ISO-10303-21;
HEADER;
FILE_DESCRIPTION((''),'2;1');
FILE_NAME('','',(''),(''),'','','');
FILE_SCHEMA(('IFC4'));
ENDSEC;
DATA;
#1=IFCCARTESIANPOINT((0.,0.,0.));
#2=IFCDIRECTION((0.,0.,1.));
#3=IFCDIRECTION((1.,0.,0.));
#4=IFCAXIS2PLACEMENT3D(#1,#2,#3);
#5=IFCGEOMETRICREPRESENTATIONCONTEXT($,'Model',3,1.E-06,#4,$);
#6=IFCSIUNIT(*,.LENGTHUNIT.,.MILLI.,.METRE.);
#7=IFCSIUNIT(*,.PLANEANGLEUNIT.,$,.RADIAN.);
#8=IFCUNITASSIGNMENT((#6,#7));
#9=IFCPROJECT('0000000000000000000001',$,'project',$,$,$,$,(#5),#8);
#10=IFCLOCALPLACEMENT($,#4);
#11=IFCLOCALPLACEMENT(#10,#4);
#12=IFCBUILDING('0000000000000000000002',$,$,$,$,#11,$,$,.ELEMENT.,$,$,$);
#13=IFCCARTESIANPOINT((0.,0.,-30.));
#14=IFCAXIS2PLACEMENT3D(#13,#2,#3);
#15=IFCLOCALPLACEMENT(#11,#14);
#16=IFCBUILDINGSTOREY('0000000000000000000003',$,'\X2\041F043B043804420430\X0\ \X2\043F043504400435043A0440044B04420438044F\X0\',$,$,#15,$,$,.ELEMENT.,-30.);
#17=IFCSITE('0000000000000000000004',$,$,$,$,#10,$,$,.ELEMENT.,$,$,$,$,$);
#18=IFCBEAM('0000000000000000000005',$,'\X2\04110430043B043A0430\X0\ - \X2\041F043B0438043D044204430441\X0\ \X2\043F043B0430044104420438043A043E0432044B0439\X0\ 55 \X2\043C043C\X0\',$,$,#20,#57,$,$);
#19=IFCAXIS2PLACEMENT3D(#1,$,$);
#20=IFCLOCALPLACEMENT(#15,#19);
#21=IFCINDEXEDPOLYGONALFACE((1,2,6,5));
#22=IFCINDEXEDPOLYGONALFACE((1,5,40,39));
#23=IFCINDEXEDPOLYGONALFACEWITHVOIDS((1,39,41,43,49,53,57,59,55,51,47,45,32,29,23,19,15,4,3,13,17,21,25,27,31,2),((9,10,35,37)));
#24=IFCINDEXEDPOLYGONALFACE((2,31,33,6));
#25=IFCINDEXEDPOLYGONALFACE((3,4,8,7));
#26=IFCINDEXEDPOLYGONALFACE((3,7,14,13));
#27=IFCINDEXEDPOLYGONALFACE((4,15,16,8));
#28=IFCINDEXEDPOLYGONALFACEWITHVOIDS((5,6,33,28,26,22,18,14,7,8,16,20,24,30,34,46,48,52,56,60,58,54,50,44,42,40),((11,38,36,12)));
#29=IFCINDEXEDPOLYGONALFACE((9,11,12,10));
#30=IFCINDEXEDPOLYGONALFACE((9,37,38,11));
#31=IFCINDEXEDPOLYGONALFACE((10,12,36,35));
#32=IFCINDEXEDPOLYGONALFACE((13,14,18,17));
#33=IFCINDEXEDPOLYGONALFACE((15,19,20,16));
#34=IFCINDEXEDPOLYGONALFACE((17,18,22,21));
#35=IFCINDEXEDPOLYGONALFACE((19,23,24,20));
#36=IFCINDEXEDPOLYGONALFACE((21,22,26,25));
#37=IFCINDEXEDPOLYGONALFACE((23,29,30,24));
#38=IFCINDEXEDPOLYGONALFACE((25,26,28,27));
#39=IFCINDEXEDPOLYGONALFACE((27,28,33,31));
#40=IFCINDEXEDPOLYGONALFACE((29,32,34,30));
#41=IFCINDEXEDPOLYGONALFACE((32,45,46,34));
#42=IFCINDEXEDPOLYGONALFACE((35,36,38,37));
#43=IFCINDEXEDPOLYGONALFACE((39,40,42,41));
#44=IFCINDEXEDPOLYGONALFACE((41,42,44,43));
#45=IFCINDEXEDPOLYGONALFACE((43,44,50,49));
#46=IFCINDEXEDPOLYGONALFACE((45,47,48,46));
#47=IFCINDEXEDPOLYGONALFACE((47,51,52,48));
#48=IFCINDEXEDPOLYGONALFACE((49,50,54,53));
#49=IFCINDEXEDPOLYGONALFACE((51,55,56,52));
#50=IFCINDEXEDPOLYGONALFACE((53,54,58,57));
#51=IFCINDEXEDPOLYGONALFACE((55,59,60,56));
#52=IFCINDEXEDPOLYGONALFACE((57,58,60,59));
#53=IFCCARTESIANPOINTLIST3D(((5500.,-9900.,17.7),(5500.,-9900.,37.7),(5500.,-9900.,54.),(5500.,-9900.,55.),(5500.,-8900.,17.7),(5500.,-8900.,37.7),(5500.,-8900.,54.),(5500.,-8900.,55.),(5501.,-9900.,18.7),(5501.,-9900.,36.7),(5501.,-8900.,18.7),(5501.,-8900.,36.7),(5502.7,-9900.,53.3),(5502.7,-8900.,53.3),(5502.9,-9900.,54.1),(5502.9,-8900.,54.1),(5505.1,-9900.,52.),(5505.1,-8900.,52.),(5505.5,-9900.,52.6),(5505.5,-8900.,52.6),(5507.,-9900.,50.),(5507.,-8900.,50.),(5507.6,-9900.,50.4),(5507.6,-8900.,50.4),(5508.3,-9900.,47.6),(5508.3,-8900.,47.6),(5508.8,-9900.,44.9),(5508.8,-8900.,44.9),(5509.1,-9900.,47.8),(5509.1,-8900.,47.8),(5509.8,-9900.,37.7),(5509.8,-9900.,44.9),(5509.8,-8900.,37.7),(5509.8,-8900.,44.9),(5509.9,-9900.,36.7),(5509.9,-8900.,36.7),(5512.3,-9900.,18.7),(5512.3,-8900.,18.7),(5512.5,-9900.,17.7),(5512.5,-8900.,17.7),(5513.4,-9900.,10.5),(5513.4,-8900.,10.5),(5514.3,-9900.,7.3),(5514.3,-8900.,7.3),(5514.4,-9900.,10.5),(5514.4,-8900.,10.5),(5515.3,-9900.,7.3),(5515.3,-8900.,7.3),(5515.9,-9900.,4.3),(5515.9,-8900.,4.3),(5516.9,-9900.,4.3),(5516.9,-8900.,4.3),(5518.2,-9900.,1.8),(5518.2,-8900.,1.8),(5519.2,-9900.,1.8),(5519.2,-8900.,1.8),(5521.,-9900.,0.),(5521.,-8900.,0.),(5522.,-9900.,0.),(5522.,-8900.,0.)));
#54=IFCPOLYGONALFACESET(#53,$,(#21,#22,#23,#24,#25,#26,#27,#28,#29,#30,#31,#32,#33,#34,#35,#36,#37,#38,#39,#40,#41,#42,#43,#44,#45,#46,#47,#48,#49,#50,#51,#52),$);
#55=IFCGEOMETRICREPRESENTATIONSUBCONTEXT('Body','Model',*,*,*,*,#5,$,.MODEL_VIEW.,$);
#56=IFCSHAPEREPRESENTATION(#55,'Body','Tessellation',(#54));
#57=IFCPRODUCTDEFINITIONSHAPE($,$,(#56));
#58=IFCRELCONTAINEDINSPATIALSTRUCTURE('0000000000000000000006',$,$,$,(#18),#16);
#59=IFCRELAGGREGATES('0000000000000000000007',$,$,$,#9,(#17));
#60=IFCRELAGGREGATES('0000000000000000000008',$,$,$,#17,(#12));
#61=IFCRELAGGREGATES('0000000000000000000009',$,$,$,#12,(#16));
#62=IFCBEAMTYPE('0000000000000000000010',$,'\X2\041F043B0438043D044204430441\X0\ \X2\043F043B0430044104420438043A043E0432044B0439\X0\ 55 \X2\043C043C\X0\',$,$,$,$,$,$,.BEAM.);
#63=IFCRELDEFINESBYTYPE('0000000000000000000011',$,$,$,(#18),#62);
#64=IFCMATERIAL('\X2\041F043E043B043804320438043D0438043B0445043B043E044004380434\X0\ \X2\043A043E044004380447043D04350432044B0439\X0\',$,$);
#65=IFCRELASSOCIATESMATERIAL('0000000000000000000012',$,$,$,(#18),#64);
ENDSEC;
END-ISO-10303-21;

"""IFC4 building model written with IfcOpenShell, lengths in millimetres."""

from ifc_helpers import new_model, si_unit, frame, origin_with_axes, place, context, subcontext, project, spatial, line, arc, indexed_curve, outline, extrude, material, type_object, element, save


model = new_model("IFC4")

# Units and contexts
model_context = context("Model", 3, precision=1e-06, world=origin_with_axes())
body_context = subcontext(model_context, "Body", "Model", "MODEL_VIEW")
ifc_project = project(units=[si_unit("LENGTHUNIT", "METRE", prefix="MILLI"), si_unit("PLANEANGLEUNIT", "RADIAN")], contexts=[model_context])

# Site, building, storey
site_placement = place(None, origin_with_axes())
site = spatial("IfcSite", under=ifc_project, at=site_placement, CompositionType="ELEMENT")
building_placement = place(site_placement, origin_with_axes())
building = spatial("IfcBuilding", under=site, at=building_placement, CompositionType="ELEMENT")
storey_placement = place(building_placement, frame((0.0, 0.0, -30.0), z_axis=(0.0, 0.0, 1.0), x_axis=(1.0, 0.0, 0.0)))
storey = spatial("IfcBuildingStorey", under=building, at=storey_placement, Name="Плита перекрытия", CompositionType="ELEMENT", Elevation=-30.0)

# Beam
ifc_material_1 = material(Name="Поливинилхлорид коричневый")
beam_type_1 = type_object("IfcBeamType", Name="Плинтус пластиковый 55 мм", PredefinedType="BEAM")
beam_1_placement = place(storey_placement, frame((5500.0, -8900.0, 0.0), z_axis=(0.0, 1.0, 0.0), x_axis=(-1.0, 0.0, 0.0)))
element("IfcBeam", 1, at=beam_1_placement, inside=storey, type_object=beam_type_1, material=ifc_material_1, Name="Балка - Плинтус пластиковый 55 мм", context=body_context, shape_type="SweptSolid", body=[
    extrude(outline(indexed_curve([(0.0, 55.0), (-6.6, 51.5), (-9.8, 44.9), (-14.4, 10.5), (-16.9, 4.3), (-22.0, 0.0), (-21.0, 0.0), (-15.9, 4.3), (-13.4, 10.5), (-12.5, 17.7), (0.0, 17.7), (0.0, 37.7), (-9.8, 37.7), (-8.8, 44.9), (-6.1, 51.0), (0.0, 54.0)], segments=[arc(1, 2, 3), line(3, 4), arc(4, 5, 6), line(6, 7), arc(7, 8, 9), line(9, 10), line(10, 11), line(11, 12), line(12, 13), line(13, 14), arc(14, 15, 16), line(16, 1)]), holes=[indexed_curve([(-9.9, 36.7), (-1.0, 36.7), (-1.0, 18.7), (-12.3, 18.7)], segments=[line(1, 2), line(2, 3), line(3, 4), line(4, 1)])]), origin_with_axes(), (0.0, 0.0, -1.0), 1000.0),
])

save(model, "model.ifc")
